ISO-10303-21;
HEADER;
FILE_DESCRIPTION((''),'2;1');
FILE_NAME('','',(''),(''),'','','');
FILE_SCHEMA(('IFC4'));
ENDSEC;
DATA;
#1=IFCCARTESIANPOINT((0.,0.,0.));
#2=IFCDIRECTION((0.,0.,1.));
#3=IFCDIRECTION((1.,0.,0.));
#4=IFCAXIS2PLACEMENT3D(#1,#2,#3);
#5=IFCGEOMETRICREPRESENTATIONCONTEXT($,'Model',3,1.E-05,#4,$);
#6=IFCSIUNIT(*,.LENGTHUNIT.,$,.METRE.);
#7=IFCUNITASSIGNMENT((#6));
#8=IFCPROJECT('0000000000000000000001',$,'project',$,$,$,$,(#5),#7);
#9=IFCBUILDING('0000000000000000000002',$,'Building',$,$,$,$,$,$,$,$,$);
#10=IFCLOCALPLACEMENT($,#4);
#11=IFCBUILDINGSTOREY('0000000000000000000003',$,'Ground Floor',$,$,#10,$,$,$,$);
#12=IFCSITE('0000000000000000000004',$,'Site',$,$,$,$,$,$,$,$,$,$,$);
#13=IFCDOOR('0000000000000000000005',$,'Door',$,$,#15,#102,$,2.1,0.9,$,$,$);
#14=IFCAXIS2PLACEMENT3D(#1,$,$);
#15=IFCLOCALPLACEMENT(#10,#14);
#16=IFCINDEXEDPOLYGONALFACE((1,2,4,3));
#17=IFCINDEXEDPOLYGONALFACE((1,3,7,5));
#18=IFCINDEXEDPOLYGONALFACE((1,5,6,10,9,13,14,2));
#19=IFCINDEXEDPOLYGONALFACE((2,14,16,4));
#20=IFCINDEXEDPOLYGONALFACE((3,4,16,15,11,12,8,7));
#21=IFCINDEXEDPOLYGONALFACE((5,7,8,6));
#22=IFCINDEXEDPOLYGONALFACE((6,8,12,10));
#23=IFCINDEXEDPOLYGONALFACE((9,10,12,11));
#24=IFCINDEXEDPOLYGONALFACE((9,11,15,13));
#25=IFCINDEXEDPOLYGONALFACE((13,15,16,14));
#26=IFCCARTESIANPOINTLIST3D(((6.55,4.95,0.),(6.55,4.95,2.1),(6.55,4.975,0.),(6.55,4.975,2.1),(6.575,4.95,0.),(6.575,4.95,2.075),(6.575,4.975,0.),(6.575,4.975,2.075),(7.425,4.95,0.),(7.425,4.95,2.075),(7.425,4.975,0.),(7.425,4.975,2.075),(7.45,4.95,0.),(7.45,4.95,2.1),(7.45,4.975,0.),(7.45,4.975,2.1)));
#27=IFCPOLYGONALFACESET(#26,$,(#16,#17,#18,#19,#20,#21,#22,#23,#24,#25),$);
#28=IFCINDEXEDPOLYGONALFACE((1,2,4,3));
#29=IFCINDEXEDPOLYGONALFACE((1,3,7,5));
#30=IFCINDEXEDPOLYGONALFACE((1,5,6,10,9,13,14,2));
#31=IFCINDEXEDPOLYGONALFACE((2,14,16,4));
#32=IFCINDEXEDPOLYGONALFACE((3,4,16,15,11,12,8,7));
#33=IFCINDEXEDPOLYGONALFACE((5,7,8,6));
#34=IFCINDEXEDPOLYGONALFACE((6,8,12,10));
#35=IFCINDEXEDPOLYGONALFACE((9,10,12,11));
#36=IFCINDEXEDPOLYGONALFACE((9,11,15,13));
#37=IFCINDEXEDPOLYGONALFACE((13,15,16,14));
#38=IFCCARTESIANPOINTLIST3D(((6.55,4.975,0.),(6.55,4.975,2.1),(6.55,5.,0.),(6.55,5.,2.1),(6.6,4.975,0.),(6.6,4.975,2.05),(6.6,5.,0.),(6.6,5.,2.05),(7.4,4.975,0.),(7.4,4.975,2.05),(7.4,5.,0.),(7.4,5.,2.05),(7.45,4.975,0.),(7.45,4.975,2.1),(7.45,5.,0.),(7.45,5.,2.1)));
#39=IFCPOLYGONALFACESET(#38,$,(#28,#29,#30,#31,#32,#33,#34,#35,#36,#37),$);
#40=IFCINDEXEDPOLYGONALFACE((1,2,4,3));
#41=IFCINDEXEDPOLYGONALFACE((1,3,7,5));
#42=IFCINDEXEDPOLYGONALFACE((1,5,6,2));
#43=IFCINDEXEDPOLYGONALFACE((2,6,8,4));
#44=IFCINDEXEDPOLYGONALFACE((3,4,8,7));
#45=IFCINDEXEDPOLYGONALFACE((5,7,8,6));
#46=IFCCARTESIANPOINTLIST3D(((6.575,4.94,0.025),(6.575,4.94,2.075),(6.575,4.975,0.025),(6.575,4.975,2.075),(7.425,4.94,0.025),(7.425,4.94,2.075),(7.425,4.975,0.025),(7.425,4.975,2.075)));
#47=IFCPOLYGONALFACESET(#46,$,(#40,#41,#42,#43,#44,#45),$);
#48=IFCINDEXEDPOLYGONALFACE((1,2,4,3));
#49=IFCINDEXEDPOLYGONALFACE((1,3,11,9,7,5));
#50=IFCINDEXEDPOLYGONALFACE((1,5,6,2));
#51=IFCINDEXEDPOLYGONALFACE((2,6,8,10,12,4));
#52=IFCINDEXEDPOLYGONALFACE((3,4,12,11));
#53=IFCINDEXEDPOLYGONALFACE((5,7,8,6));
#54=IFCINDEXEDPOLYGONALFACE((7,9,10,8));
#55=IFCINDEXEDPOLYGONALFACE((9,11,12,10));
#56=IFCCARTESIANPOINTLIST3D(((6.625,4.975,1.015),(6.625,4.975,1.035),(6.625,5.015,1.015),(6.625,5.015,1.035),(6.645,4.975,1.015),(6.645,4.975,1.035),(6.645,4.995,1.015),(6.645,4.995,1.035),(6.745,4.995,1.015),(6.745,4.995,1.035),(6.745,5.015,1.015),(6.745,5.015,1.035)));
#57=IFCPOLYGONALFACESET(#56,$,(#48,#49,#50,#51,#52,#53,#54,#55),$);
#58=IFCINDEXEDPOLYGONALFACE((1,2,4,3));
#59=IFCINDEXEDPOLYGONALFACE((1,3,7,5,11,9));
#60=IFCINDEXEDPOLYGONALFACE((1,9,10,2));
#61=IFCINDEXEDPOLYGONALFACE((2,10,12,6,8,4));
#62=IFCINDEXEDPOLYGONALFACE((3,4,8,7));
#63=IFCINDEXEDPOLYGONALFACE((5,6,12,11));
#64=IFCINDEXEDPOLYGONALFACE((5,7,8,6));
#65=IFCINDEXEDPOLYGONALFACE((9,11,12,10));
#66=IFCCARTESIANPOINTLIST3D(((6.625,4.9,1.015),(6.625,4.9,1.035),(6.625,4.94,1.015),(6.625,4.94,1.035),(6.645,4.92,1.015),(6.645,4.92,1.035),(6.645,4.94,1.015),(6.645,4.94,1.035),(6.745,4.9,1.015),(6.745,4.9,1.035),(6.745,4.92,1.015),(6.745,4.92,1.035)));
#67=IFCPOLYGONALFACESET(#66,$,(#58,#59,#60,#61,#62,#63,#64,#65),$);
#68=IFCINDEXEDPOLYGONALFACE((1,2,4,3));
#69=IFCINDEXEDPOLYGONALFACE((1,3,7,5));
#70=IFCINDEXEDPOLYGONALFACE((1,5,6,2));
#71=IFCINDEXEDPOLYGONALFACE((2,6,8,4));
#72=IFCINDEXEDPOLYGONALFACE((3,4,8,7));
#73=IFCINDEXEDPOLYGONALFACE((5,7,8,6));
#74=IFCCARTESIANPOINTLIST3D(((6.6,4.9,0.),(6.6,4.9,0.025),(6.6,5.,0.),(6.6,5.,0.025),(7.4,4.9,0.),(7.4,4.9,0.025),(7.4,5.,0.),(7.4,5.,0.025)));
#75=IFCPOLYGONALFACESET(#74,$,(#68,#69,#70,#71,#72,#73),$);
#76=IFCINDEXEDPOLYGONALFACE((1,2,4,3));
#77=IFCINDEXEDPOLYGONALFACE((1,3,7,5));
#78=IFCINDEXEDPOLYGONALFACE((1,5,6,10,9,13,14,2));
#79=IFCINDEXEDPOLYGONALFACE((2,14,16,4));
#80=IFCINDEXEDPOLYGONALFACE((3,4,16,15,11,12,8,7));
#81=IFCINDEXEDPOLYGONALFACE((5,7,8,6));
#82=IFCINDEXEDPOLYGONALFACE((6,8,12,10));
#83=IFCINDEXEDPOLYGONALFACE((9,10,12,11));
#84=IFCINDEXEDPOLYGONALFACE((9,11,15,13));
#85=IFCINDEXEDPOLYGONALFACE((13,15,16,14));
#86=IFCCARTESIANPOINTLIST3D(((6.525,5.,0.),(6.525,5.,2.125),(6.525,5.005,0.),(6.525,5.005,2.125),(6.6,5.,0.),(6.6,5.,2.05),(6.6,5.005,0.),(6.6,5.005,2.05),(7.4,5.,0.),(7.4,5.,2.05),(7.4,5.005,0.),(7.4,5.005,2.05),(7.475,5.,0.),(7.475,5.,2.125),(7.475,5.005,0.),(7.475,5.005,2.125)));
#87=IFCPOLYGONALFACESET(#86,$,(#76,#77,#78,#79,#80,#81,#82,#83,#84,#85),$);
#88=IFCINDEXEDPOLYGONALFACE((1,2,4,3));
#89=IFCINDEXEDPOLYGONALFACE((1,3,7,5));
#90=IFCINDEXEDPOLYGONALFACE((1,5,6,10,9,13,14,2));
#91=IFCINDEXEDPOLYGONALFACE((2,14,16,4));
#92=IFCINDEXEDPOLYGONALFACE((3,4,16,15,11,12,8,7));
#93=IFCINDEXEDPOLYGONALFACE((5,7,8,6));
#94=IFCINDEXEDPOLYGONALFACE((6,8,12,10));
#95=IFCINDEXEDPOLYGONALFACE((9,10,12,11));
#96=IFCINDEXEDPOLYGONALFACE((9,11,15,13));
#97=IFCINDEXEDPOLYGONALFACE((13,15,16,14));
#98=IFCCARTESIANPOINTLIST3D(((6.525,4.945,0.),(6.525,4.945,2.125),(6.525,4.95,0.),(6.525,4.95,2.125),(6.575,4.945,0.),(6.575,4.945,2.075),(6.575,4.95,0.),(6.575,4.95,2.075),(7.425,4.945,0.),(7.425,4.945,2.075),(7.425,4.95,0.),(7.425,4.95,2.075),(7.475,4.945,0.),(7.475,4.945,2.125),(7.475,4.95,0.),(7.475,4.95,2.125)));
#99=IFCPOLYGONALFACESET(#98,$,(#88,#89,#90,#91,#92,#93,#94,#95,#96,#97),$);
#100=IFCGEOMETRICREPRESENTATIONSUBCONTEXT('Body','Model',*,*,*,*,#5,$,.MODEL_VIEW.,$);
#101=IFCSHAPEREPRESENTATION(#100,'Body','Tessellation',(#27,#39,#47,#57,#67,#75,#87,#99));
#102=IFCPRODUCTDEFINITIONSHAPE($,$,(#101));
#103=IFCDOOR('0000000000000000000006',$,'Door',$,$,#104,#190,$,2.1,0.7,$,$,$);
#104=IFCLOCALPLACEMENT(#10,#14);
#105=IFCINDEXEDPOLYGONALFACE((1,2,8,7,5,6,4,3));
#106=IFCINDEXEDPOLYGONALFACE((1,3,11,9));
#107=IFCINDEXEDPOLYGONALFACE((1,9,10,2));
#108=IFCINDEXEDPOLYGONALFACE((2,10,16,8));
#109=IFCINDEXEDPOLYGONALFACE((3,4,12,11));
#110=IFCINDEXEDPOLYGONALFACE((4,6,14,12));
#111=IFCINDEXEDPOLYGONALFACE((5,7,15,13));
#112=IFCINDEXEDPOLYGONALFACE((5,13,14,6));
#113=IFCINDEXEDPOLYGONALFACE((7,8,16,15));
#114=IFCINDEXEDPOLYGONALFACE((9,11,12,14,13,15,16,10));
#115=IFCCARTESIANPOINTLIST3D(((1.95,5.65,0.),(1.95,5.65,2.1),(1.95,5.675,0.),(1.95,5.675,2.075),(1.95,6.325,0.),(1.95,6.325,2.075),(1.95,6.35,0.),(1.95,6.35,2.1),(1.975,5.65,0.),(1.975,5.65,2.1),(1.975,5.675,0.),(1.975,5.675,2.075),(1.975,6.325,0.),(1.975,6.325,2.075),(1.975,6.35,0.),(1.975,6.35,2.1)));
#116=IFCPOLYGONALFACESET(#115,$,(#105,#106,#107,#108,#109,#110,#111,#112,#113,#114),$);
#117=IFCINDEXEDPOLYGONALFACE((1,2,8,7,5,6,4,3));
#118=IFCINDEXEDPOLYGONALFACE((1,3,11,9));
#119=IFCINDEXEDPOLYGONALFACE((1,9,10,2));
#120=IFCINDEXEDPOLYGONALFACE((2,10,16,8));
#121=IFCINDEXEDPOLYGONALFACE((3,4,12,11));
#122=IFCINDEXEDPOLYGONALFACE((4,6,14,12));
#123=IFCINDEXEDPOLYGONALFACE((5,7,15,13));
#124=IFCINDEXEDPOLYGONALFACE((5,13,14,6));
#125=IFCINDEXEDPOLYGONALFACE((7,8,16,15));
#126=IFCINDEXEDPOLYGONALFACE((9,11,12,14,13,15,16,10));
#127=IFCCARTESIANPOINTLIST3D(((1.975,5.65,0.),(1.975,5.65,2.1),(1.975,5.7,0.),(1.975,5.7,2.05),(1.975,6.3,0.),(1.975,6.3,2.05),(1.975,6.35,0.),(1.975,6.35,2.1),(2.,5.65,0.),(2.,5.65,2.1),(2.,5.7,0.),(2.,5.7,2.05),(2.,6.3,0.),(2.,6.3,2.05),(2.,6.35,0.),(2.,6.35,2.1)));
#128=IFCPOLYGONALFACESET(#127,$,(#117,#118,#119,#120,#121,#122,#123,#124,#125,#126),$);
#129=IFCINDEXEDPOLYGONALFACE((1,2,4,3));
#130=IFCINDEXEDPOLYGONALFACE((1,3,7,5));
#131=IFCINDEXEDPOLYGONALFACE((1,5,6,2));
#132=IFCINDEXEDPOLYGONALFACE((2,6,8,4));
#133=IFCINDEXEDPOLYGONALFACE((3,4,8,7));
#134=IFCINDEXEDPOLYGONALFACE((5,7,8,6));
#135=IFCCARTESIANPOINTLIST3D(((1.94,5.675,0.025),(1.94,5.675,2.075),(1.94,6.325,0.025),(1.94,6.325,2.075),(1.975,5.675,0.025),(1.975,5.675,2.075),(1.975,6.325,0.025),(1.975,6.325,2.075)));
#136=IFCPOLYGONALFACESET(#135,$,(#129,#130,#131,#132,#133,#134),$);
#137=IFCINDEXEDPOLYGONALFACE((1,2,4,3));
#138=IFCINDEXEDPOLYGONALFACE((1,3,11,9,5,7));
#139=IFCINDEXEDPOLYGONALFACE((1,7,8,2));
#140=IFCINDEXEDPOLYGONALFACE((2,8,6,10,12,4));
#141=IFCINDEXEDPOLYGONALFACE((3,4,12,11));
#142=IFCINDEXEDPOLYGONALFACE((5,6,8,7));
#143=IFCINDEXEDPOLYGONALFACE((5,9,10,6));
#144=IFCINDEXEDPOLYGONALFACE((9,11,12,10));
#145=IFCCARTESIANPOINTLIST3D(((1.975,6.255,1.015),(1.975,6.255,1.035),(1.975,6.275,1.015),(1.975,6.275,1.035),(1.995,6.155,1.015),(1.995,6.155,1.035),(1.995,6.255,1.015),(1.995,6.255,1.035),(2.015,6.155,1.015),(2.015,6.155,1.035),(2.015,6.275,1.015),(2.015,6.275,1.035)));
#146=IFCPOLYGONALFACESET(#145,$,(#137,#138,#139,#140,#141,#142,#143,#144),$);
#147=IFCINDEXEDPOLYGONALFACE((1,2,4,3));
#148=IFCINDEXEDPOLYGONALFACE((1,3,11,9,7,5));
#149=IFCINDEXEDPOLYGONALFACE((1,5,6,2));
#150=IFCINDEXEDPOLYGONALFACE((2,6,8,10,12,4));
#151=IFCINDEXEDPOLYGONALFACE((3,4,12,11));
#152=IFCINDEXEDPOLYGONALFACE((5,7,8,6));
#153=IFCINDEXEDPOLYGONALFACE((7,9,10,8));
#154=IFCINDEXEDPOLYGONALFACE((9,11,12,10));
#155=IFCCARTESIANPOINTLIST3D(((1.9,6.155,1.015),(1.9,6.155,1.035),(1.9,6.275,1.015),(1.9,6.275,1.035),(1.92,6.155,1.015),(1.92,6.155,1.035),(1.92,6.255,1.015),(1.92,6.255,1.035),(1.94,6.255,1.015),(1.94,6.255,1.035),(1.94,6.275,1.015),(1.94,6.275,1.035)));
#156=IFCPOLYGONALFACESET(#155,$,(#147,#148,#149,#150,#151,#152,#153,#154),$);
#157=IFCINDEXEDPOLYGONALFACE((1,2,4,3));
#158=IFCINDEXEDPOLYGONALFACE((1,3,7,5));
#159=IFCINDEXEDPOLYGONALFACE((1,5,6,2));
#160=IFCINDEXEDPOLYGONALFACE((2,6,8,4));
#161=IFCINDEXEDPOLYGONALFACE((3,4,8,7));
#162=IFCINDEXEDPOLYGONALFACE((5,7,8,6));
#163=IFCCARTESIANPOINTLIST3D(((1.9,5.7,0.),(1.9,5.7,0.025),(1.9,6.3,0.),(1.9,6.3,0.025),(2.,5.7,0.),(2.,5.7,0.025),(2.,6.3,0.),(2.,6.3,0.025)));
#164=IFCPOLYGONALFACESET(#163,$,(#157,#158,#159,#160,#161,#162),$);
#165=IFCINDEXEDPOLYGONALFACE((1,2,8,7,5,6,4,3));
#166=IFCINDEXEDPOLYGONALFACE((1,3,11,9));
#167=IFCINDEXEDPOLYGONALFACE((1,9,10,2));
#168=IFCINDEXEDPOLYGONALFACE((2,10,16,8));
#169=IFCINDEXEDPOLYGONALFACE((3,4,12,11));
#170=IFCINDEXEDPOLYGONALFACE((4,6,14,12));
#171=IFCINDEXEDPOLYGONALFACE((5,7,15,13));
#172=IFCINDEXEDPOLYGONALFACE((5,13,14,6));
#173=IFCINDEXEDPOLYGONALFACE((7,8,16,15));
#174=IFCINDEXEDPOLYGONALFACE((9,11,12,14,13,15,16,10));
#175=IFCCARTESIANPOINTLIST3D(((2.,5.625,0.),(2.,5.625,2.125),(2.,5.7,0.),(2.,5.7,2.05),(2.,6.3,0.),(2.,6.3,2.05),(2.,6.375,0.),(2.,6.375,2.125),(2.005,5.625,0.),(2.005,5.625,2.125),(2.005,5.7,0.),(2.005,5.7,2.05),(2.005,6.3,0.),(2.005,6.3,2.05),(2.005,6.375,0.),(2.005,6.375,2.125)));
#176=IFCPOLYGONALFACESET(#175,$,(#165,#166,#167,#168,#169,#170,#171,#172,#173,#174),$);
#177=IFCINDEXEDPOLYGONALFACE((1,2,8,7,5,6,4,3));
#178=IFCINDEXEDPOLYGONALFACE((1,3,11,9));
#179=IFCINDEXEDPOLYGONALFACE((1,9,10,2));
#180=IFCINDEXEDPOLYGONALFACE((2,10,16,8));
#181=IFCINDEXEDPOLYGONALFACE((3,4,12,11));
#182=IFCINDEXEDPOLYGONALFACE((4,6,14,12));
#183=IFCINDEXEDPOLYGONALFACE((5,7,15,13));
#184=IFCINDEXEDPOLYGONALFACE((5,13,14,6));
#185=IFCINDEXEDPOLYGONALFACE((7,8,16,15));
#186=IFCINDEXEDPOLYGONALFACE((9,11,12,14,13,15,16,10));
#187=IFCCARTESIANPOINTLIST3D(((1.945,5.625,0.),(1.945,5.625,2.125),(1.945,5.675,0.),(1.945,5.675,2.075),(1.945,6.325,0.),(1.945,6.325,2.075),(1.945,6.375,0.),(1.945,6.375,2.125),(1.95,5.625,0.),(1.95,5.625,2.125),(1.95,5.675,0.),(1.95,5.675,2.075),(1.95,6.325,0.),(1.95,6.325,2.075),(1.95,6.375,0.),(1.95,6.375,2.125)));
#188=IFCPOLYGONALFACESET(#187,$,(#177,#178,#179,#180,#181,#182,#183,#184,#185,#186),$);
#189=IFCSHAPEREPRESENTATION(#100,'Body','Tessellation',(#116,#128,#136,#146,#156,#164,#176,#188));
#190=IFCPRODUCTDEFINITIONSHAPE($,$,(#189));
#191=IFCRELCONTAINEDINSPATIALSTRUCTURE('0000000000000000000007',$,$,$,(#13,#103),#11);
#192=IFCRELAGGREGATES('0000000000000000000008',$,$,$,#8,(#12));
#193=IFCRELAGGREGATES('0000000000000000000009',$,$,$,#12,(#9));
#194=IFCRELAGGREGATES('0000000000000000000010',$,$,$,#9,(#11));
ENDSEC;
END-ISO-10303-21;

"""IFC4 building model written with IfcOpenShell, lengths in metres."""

from ifc_helpers import new_model, si_unit, frame, origin_with_axes, place, context, subcontext, project, spatial, line, indexed_curve, outline, extrude, element, save


model = new_model("IFC4")

# Units and contexts
model_context = context("Model", 3, precision=1e-05, world=origin_with_axes())
body_context = subcontext(model_context, "Body", "Model", "MODEL_VIEW")
ifc_project = project(units=[si_unit("LENGTHUNIT", "METRE")], contexts=[model_context])

# Site, building, storey
site = spatial("IfcSite", under=ifc_project, Name="Site")
building = spatial("IfcBuilding", under=site, Name="Building")
storey_placement = place(None, origin_with_axes())
storey = spatial("IfcBuildingStorey", under=building, at=storey_placement, Name="Ground Floor")

# Doors
door_1_placement = place(storey_placement, frame((7.45, 5.0, 0.0), z_axis=(0.0, 0.0, 1.0), x_axis=(-1.0, 0.0, 0.0)))
element("IfcDoor", 1, at=door_1_placement, inside=storey, Name="Door", OverallHeight=2.1, OverallWidth=0.9, context=body_context, shape_type="SweptSolid", body=[
    extrude(outline(indexed_curve([(0.0, 0.0), (0.0, 2.1), (0.9, 2.1), (0.9, 0.0), (0.875, 0.0), (0.875, 2.075), (0.025, 2.075), (0.025, 0.0)], segments=[line(1, 2, 3, 4, 5, 6, 7, 8, 1)])), frame((0.0, 0.025, 0.0), z_axis=(0.0, -1.0, 0.0), x_axis=(1.0, 0.0, 0.0)), (0.0, 0.0, -1.0), 0.025),
    extrude(outline(indexed_curve([(0.0, 0.0), (0.0, 2.1), (0.9, 2.1), (0.9, 0.0), (0.85, 0.0), (0.85, 2.05), (0.05, 2.05), (0.05, 0.0)], segments=[line(1, 2, 3, 4, 5, 6, 7, 8, 1)])), frame((0.0, 0.0, 0.0), z_axis=(0.0, -1.0, 0.0), x_axis=(1.0, 0.0, 0.0)), (0.0, 0.0, -1.0), 0.025),
    extrude(outline(indexed_curve([(0.0, 0.0), (0.85, 0.0), (0.85, 0.035), (0.0, 0.035)], segments=[line(1, 2, 3, 4, 1)])), frame((0.025, 0.025, 0.025), z_axis=(0.0, 0.0, 1.0), x_axis=(1.0, 0.0, 0.0)), (0.0, 0.0, 1.0), 2.05),
    extrude(outline(indexed_curve([(0.0, 0.0), (0.0, -0.04), (-0.12, -0.04), (-0.12, -0.02), (-0.02, -0.02), (-0.02, 0.0)], segments=[line(1, 2, 3, 4, 5, 6, 1)])), frame((0.825, 0.025, 1.015), z_axis=(0.0, 0.0, 1.0), x_axis=(1.0, 0.0, 0.0)), (0.0, 0.0, 1.0), 0.02),
    extrude(outline(indexed_curve([(0.0, 0.0), (0.0, 0.04), (-0.12, 0.04), (-0.12, 0.02), (-0.02, 0.02), (-0.02, 0.0)], segments=[line(1, 2, 3, 4, 5, 6, 1)])), frame((0.825, 0.06, 1.015), z_axis=(0.0, 0.0, 1.0), x_axis=(1.0, 0.0, 0.0)), (0.0, 0.0, 1.0), 0.02),
    extrude(outline(indexed_curve([(0.0, 0.0), (0.8, 0.0), (0.8, 0.1), (0.0, 0.1)], segments=[line(1, 2, 3, 4, 1)])), frame((0.05, 0.0, 0.0), z_axis=(0.0, 0.0, 1.0), x_axis=(1.0, 0.0, 0.0)), (0.0, 0.0, 1.0), 0.025),
    extrude(outline(indexed_curve([(0.0, 0.0), (0.0, 2.125), (0.95, 2.125), (0.95, 0.0), (0.875, 0.0), (0.875, 2.05), (0.075, 2.05), (0.075, 0.0)], segments=[line(1, 2, 3, 4, 5, 6, 7, 8, 1)])), frame((-0.025, -0.005, 0.0), z_axis=(0.0, -1.0, 0.0), x_axis=(1.0, 0.0, 0.0)), (0.0, 0.0, -1.0), 0.005),
    extrude(outline(indexed_curve([(0.0, 0.0), (0.0, 2.125), (0.95, 2.125), (0.95, 0.0), (0.9, 0.0), (0.9, 2.075), (0.05, 2.075), (0.05, 0.0)], segments=[line(1, 2, 3, 4, 5, 6, 7, 8, 1)])), frame((-0.025, 0.05, 0.0), z_axis=(0.0, -1.0, 0.0), x_axis=(1.0, 0.0, 0.0)), (0.0, 0.0, -1.0), 0.005),
])
door_2_placement = place(storey_placement, frame((2.0, 5.65, 0.0), z_axis=(0.0, 0.0, 1.0), x_axis=(0.0, 1.0, 0.0)))
element("IfcDoor", 2, at=door_2_placement, inside=storey, Name="Door", OverallHeight=2.1, OverallWidth=0.7, context=body_context, shape_type="SweptSolid", body=[
    extrude(outline(indexed_curve([(0.0, 0.0), (0.0, 2.1), (0.7, 2.1), (0.7, 0.0), (0.675, 0.0), (0.675, 2.075), (0.025, 2.075), (0.025, 0.0)], segments=[line(1, 2, 3, 4, 5, 6, 7, 8, 1)])), frame((0.0, 0.025, 0.0), z_axis=(0.0, -1.0, 0.0), x_axis=(1.0, 0.0, 0.0)), (0.0, 0.0, -1.0), 0.025),
    extrude(outline(indexed_curve([(0.0, 0.0), (0.0, 2.1), (0.7, 2.1), (0.7, 0.0), (0.65, 0.0), (0.65, 2.05), (0.05, 2.05), (0.05, 0.0)], segments=[line(1, 2, 3, 4, 5, 6, 7, 8, 1)])), frame((0.0, 0.0, 0.0), z_axis=(0.0, -1.0, 0.0), x_axis=(1.0, 0.0, 0.0)), (0.0, 0.0, -1.0), 0.025),
    extrude(outline(indexed_curve([(0.0, 0.0), (0.65, 0.0), (0.65, 0.035), (0.0, 0.035)], segments=[line(1, 2, 3, 4, 1)])), frame((0.025, 0.025, 0.025), z_axis=(0.0, 0.0, 1.0), x_axis=(1.0, 0.0, 0.0)), (0.0, 0.0, 1.0), 2.05),
    extrude(outline(indexed_curve([(0.0, 0.0), (0.0, -0.04), (-0.12, -0.04), (-0.12, -0.02), (-0.02, -0.02), (-0.02, 0.0)], segments=[line(1, 2, 3, 4, 5, 6, 1)])), frame((0.625, 0.025, 1.015), z_axis=(0.0, 0.0, 1.0), x_axis=(1.0, 0.0, 0.0)), (0.0, 0.0, 1.0), 0.02),
    extrude(outline(indexed_curve([(0.0, 0.0), (0.0, 0.04), (-0.12, 0.04), (-0.12, 0.02), (-0.02, 0.02), (-0.02, 0.0)], segments=[line(1, 2, 3, 4, 5, 6, 1)])), frame((0.625, 0.06, 1.015), z_axis=(0.0, 0.0, 1.0), x_axis=(1.0, 0.0, 0.0)), (0.0, 0.0, 1.0), 0.02),
    extrude(outline(indexed_curve([(0.0, 0.0), (0.6, 0.0), (0.6, 0.1), (0.0, 0.1)], segments=[line(1, 2, 3, 4, 1)])), frame((0.05, 0.0, 0.0), z_axis=(0.0, 0.0, 1.0), x_axis=(1.0, 0.0, 0.0)), (0.0, 0.0, 1.0), 0.025),
    extrude(outline(indexed_curve([(0.0, 0.0), (0.0, 2.125), (0.75, 2.125), (0.75, 0.0), (0.675, 0.0), (0.675, 2.05), (0.075, 2.05), (0.075, 0.0)], segments=[line(1, 2, 3, 4, 5, 6, 7, 8, 1)])), frame((-0.025, -0.005, 0.0), z_axis=(0.0, -1.0, 0.0), x_axis=(1.0, 0.0, 0.0)), (0.0, 0.0, -1.0), 0.005),
    extrude(outline(indexed_curve([(0.0, 0.0), (0.0, 2.125), (0.75, 2.125), (0.75, 0.0), (0.7, 0.0), (0.7, 2.075), (0.05, 2.075), (0.05, 0.0)], segments=[line(1, 2, 3, 4, 5, 6, 7, 8, 1)])), frame((-0.025, 0.05, 0.0), z_axis=(0.0, -1.0, 0.0), x_axis=(1.0, 0.0, 0.0)), (0.0, 0.0, -1.0), 0.005),
])

save(model, "model.ifc")
